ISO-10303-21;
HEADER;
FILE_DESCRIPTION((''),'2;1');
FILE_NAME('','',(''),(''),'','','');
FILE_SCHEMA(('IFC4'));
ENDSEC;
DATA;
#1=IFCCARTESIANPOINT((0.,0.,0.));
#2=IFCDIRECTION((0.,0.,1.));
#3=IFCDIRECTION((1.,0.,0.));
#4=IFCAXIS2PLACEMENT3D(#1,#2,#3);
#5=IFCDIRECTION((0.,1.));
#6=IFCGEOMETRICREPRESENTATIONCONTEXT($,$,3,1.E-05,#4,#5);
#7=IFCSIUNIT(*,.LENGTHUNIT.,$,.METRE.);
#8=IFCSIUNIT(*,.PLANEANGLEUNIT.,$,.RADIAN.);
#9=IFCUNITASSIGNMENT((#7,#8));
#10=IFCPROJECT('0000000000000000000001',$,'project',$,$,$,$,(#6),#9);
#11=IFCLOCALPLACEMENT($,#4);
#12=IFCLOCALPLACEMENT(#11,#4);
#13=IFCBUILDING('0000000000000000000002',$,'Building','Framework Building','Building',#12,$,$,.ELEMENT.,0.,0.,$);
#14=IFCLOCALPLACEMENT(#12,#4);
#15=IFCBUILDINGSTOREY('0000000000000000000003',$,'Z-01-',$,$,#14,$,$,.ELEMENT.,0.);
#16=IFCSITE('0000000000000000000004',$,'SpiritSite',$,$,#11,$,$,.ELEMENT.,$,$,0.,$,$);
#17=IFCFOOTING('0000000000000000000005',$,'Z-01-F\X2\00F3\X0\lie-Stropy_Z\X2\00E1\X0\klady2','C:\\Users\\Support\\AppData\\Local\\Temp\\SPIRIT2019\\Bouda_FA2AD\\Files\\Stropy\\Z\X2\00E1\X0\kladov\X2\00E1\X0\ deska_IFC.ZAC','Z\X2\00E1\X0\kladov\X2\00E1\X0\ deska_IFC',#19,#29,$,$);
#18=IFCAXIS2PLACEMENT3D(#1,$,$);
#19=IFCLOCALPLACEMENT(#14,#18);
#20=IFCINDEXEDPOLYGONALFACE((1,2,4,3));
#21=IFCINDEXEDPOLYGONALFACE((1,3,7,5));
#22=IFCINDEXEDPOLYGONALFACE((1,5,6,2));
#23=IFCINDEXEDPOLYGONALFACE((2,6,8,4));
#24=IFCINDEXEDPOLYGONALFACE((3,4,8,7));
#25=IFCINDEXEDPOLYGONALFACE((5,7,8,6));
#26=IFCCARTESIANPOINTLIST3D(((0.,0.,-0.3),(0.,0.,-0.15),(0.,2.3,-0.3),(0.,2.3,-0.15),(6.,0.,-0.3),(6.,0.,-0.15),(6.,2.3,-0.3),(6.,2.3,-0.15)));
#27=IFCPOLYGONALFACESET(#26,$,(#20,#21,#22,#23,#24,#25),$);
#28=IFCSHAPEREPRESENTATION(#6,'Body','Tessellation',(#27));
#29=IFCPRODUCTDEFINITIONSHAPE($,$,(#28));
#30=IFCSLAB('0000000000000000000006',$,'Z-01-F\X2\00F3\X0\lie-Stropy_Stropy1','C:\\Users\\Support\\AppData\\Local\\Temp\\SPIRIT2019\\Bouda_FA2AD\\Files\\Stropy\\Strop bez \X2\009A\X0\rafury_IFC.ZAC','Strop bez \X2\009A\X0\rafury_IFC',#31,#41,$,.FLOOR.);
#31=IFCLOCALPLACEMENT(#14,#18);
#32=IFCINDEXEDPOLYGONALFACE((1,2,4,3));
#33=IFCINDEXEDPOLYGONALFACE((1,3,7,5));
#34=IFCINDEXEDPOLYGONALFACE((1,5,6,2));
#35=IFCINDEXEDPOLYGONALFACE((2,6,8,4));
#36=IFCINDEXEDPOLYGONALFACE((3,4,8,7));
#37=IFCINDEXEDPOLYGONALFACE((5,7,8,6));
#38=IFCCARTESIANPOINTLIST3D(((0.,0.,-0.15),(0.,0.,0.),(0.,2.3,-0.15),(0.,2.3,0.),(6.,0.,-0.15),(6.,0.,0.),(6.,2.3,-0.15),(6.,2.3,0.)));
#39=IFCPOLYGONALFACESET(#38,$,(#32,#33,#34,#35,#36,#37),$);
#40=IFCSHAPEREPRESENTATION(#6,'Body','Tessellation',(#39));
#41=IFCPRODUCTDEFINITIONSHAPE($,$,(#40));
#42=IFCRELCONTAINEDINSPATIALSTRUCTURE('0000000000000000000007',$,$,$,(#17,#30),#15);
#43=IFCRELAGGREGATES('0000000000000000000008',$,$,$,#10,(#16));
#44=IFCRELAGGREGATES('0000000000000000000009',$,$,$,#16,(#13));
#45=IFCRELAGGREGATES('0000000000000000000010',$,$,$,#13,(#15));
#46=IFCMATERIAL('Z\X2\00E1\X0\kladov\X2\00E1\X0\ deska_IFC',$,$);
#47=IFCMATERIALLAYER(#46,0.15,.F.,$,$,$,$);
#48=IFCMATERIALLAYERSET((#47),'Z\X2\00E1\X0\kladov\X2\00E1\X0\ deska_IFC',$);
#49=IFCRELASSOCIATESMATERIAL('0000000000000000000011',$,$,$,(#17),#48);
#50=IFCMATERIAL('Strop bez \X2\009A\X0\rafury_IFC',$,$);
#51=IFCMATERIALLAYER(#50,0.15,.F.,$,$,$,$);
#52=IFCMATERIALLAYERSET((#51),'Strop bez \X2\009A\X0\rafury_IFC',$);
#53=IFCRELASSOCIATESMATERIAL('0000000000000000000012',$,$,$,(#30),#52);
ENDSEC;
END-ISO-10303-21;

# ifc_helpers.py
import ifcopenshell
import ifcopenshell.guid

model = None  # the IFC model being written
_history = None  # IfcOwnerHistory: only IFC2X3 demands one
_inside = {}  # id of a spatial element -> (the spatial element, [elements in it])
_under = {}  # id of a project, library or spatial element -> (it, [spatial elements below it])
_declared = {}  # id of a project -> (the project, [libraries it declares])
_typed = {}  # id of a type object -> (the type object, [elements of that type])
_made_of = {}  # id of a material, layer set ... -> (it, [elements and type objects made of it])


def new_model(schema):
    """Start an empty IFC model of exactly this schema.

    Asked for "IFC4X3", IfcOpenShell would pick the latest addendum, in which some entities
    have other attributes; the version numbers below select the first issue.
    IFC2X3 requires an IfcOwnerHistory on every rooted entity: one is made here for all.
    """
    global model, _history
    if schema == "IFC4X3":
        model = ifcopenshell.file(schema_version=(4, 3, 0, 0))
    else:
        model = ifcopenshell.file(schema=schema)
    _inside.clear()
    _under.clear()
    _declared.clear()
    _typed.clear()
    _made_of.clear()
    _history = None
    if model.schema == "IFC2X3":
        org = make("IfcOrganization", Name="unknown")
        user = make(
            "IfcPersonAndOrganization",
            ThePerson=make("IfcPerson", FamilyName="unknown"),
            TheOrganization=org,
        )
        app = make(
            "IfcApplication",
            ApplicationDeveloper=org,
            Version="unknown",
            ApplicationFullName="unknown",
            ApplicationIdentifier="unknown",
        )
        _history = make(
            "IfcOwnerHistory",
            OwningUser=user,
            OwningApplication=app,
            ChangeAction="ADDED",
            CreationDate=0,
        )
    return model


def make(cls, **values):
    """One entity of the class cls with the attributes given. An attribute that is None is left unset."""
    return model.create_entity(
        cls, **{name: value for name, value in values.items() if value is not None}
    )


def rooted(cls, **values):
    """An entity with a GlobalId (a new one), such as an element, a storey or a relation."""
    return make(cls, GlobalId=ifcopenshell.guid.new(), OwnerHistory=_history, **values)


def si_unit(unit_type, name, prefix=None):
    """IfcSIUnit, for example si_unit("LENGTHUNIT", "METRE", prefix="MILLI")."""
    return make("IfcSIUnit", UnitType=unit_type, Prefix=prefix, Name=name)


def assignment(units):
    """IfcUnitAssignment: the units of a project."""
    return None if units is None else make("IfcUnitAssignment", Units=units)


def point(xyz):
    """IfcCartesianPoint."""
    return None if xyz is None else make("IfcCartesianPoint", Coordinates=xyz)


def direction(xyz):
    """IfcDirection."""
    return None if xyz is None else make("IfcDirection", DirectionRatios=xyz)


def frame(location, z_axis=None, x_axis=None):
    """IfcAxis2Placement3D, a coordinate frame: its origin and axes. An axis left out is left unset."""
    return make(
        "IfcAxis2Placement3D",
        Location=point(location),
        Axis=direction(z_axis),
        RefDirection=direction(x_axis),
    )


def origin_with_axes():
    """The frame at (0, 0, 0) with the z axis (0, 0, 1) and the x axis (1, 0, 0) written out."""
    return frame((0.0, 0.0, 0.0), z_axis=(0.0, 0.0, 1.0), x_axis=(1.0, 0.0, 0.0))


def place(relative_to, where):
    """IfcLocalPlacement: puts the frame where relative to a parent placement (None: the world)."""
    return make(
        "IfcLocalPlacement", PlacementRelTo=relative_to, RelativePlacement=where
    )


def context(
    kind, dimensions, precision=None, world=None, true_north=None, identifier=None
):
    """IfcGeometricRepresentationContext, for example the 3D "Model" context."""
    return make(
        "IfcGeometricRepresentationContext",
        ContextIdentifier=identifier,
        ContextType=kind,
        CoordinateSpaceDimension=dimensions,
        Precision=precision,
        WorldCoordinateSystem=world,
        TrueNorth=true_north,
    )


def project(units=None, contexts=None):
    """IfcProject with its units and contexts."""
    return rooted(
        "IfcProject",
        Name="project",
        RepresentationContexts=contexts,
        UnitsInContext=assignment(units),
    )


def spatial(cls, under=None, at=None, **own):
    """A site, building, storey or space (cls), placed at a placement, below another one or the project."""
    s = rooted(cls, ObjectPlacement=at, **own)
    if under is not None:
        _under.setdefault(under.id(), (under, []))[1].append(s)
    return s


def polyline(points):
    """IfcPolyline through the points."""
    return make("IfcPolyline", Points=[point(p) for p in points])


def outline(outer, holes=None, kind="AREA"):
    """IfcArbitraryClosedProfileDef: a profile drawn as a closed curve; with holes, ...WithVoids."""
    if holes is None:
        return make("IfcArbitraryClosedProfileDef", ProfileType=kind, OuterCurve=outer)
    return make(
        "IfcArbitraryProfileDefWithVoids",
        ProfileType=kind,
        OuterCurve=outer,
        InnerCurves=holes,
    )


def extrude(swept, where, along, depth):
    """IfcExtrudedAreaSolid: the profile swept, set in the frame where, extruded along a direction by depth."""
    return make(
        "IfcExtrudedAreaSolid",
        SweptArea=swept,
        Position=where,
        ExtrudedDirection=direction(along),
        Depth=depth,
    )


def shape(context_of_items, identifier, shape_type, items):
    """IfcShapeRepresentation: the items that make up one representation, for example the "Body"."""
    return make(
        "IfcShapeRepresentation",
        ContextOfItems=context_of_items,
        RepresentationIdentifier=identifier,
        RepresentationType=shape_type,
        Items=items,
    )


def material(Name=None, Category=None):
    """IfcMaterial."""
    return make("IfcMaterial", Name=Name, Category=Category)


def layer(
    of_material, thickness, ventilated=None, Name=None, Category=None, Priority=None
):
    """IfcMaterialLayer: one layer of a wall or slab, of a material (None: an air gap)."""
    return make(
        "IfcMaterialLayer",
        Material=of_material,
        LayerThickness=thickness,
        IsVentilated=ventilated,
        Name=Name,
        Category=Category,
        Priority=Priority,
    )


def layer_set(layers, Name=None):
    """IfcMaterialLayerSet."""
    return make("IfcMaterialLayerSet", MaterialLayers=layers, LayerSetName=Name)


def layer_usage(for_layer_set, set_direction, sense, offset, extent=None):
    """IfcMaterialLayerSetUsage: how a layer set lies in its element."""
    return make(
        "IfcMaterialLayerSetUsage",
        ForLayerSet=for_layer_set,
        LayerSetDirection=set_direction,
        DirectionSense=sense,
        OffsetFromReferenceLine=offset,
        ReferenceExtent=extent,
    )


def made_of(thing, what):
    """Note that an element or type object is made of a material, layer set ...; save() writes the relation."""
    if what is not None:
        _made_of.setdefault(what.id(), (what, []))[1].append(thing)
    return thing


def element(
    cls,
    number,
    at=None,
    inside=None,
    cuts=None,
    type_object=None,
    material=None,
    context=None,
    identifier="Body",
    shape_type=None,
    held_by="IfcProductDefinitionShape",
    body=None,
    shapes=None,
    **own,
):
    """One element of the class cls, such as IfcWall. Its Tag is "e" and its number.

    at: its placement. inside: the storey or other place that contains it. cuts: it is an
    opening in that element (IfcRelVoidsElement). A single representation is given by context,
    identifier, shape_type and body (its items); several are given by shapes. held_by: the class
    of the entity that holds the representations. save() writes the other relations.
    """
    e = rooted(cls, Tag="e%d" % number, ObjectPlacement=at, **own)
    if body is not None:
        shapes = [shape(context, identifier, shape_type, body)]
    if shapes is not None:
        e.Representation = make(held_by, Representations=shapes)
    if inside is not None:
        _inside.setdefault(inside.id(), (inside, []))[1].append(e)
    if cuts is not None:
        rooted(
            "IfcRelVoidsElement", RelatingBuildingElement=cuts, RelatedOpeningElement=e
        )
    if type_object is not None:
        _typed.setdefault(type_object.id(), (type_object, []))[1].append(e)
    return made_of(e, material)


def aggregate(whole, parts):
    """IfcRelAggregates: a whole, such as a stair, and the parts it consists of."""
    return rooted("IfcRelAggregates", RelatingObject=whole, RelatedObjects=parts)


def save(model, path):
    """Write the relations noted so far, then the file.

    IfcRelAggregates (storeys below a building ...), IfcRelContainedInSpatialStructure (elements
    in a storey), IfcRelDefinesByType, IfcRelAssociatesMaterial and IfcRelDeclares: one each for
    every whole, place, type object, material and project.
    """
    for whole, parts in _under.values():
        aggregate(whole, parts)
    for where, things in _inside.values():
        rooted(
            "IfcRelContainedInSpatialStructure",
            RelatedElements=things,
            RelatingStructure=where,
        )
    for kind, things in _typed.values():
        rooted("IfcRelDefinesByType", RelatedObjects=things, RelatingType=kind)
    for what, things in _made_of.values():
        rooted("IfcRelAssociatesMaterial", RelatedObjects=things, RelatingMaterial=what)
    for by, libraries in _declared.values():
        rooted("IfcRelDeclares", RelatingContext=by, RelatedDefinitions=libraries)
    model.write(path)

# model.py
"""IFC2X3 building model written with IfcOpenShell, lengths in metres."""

from ifc_helpers import new_model, si_unit, direction, frame, origin_with_axes, place, context, project, spatial, polyline, outline, extrude, material, layer, layer_set, layer_usage, element, save


model = new_model("IFC2X3")

# Units and contexts
context_of_model = context(None, 3, precision=1e-05, world=origin_with_axes(), true_north=direction((0.0, 1.0)))
ifc_project = project(units=[si_unit("LENGTHUNIT", "METRE"), si_unit("PLANEANGLEUNIT", "RADIAN")], contexts=[context_of_model])

# Site, building, storey
site_placement = place(None, origin_with_axes())
site = spatial("IfcSite", under=ifc_project, at=site_placement, Name="SpiritSite", CompositionType="ELEMENT", RefElevation=0.0)
building_placement = place(site_placement, origin_with_axes())
building = spatial("IfcBuilding", under=site, at=building_placement, Name="Building", Description="Framework Building", ObjectType="Building", CompositionType="ELEMENT", ElevationOfRefHeight=0.0, ElevationOfTerrain=0.0)
storey_placement = place(building_placement, origin_with_axes())
storey = spatial("IfcBuildingStorey", under=building, at=storey_placement, Name="Z-01-", CompositionType="ELEMENT", Elevation=0.0)

# Footing
ifc_material_1 = material(Name="Základová deska_IFC")
ifc_layer_1 = layer(ifc_material_1, 0.15, ventilated=False)
ifc_layer_set_1 = layer_set([ifc_layer_1], Name="Základová deska_IFC")
ifc_layer_usage_1 = layer_usage(ifc_layer_set_1, "AXIS3", "POSITIVE", 0.0)
footing_placement = place(storey_placement, frame((0.0, 0.0, -0.3), z_axis=(0.0, 0.0, 1.0), x_axis=(1.0, 0.0, 0.0)))
element("IfcFooting", 1, at=footing_placement, inside=storey, material=ifc_layer_usage_1, Name="Z-01-Fólie-Stropy_Základy2", Description="C:\\Users\\Support\\AppData\\Local\\Temp\\SPIRIT2019\\Bouda_FA2AD\\Files\\Stropy\\Základová deska_IFC.ZAC", ObjectType="Základová deska_IFC", context=context_of_model, shape_type="SweptSolid", body=[
    extrude(outline(polyline([(0.0, 2.3), (6.0, 2.3), (6.0, 0.0), (0.0, 0.0), (0.0, 2.3)])), origin_with_axes(), (0.0, 0.0, 1.0), 0.15),
])

# Slab
ifc_material_2 = material(Name="Strop bez \u009arafury_IFC")
ifc_layer_2 = layer(ifc_material_2, 0.15, ventilated=False)
ifc_layer_set_2 = layer_set([ifc_layer_2], Name="Strop bez \u009arafury_IFC")
ifc_layer_usage_2 = layer_usage(ifc_layer_set_2, "AXIS3", "POSITIVE", 0.0)
slab_placement = place(storey_placement, frame((0.0, 0.0, -0.15), z_axis=(0.0, 0.0, 1.0), x_axis=(1.0, 0.0, 0.0)))
element("IfcSlab", 2, at=slab_placement, inside=storey, material=ifc_layer_usage_2, Name="Z-01-Fólie-Stropy_Stropy1", Description="C:\\Users\\Support\\AppData\\Local\\Temp\\SPIRIT2019\\Bouda_FA2AD\\Files\\Stropy\\Strop bez \u009arafury_IFC.ZAC", ObjectType="Strop bez \u009arafury_IFC", PredefinedType="FLOOR", context=context_of_model, shape_type="SweptSolid", body=[
    extrude(outline(polyline([(0.0, 2.3), (6.0, 2.3), (6.0, 0.0), (0.0, 0.0), (0.0, 2.3)])), origin_with_axes(), (0.0, 0.0, 1.0), 0.15),
])

save(model, "model.ifc")
